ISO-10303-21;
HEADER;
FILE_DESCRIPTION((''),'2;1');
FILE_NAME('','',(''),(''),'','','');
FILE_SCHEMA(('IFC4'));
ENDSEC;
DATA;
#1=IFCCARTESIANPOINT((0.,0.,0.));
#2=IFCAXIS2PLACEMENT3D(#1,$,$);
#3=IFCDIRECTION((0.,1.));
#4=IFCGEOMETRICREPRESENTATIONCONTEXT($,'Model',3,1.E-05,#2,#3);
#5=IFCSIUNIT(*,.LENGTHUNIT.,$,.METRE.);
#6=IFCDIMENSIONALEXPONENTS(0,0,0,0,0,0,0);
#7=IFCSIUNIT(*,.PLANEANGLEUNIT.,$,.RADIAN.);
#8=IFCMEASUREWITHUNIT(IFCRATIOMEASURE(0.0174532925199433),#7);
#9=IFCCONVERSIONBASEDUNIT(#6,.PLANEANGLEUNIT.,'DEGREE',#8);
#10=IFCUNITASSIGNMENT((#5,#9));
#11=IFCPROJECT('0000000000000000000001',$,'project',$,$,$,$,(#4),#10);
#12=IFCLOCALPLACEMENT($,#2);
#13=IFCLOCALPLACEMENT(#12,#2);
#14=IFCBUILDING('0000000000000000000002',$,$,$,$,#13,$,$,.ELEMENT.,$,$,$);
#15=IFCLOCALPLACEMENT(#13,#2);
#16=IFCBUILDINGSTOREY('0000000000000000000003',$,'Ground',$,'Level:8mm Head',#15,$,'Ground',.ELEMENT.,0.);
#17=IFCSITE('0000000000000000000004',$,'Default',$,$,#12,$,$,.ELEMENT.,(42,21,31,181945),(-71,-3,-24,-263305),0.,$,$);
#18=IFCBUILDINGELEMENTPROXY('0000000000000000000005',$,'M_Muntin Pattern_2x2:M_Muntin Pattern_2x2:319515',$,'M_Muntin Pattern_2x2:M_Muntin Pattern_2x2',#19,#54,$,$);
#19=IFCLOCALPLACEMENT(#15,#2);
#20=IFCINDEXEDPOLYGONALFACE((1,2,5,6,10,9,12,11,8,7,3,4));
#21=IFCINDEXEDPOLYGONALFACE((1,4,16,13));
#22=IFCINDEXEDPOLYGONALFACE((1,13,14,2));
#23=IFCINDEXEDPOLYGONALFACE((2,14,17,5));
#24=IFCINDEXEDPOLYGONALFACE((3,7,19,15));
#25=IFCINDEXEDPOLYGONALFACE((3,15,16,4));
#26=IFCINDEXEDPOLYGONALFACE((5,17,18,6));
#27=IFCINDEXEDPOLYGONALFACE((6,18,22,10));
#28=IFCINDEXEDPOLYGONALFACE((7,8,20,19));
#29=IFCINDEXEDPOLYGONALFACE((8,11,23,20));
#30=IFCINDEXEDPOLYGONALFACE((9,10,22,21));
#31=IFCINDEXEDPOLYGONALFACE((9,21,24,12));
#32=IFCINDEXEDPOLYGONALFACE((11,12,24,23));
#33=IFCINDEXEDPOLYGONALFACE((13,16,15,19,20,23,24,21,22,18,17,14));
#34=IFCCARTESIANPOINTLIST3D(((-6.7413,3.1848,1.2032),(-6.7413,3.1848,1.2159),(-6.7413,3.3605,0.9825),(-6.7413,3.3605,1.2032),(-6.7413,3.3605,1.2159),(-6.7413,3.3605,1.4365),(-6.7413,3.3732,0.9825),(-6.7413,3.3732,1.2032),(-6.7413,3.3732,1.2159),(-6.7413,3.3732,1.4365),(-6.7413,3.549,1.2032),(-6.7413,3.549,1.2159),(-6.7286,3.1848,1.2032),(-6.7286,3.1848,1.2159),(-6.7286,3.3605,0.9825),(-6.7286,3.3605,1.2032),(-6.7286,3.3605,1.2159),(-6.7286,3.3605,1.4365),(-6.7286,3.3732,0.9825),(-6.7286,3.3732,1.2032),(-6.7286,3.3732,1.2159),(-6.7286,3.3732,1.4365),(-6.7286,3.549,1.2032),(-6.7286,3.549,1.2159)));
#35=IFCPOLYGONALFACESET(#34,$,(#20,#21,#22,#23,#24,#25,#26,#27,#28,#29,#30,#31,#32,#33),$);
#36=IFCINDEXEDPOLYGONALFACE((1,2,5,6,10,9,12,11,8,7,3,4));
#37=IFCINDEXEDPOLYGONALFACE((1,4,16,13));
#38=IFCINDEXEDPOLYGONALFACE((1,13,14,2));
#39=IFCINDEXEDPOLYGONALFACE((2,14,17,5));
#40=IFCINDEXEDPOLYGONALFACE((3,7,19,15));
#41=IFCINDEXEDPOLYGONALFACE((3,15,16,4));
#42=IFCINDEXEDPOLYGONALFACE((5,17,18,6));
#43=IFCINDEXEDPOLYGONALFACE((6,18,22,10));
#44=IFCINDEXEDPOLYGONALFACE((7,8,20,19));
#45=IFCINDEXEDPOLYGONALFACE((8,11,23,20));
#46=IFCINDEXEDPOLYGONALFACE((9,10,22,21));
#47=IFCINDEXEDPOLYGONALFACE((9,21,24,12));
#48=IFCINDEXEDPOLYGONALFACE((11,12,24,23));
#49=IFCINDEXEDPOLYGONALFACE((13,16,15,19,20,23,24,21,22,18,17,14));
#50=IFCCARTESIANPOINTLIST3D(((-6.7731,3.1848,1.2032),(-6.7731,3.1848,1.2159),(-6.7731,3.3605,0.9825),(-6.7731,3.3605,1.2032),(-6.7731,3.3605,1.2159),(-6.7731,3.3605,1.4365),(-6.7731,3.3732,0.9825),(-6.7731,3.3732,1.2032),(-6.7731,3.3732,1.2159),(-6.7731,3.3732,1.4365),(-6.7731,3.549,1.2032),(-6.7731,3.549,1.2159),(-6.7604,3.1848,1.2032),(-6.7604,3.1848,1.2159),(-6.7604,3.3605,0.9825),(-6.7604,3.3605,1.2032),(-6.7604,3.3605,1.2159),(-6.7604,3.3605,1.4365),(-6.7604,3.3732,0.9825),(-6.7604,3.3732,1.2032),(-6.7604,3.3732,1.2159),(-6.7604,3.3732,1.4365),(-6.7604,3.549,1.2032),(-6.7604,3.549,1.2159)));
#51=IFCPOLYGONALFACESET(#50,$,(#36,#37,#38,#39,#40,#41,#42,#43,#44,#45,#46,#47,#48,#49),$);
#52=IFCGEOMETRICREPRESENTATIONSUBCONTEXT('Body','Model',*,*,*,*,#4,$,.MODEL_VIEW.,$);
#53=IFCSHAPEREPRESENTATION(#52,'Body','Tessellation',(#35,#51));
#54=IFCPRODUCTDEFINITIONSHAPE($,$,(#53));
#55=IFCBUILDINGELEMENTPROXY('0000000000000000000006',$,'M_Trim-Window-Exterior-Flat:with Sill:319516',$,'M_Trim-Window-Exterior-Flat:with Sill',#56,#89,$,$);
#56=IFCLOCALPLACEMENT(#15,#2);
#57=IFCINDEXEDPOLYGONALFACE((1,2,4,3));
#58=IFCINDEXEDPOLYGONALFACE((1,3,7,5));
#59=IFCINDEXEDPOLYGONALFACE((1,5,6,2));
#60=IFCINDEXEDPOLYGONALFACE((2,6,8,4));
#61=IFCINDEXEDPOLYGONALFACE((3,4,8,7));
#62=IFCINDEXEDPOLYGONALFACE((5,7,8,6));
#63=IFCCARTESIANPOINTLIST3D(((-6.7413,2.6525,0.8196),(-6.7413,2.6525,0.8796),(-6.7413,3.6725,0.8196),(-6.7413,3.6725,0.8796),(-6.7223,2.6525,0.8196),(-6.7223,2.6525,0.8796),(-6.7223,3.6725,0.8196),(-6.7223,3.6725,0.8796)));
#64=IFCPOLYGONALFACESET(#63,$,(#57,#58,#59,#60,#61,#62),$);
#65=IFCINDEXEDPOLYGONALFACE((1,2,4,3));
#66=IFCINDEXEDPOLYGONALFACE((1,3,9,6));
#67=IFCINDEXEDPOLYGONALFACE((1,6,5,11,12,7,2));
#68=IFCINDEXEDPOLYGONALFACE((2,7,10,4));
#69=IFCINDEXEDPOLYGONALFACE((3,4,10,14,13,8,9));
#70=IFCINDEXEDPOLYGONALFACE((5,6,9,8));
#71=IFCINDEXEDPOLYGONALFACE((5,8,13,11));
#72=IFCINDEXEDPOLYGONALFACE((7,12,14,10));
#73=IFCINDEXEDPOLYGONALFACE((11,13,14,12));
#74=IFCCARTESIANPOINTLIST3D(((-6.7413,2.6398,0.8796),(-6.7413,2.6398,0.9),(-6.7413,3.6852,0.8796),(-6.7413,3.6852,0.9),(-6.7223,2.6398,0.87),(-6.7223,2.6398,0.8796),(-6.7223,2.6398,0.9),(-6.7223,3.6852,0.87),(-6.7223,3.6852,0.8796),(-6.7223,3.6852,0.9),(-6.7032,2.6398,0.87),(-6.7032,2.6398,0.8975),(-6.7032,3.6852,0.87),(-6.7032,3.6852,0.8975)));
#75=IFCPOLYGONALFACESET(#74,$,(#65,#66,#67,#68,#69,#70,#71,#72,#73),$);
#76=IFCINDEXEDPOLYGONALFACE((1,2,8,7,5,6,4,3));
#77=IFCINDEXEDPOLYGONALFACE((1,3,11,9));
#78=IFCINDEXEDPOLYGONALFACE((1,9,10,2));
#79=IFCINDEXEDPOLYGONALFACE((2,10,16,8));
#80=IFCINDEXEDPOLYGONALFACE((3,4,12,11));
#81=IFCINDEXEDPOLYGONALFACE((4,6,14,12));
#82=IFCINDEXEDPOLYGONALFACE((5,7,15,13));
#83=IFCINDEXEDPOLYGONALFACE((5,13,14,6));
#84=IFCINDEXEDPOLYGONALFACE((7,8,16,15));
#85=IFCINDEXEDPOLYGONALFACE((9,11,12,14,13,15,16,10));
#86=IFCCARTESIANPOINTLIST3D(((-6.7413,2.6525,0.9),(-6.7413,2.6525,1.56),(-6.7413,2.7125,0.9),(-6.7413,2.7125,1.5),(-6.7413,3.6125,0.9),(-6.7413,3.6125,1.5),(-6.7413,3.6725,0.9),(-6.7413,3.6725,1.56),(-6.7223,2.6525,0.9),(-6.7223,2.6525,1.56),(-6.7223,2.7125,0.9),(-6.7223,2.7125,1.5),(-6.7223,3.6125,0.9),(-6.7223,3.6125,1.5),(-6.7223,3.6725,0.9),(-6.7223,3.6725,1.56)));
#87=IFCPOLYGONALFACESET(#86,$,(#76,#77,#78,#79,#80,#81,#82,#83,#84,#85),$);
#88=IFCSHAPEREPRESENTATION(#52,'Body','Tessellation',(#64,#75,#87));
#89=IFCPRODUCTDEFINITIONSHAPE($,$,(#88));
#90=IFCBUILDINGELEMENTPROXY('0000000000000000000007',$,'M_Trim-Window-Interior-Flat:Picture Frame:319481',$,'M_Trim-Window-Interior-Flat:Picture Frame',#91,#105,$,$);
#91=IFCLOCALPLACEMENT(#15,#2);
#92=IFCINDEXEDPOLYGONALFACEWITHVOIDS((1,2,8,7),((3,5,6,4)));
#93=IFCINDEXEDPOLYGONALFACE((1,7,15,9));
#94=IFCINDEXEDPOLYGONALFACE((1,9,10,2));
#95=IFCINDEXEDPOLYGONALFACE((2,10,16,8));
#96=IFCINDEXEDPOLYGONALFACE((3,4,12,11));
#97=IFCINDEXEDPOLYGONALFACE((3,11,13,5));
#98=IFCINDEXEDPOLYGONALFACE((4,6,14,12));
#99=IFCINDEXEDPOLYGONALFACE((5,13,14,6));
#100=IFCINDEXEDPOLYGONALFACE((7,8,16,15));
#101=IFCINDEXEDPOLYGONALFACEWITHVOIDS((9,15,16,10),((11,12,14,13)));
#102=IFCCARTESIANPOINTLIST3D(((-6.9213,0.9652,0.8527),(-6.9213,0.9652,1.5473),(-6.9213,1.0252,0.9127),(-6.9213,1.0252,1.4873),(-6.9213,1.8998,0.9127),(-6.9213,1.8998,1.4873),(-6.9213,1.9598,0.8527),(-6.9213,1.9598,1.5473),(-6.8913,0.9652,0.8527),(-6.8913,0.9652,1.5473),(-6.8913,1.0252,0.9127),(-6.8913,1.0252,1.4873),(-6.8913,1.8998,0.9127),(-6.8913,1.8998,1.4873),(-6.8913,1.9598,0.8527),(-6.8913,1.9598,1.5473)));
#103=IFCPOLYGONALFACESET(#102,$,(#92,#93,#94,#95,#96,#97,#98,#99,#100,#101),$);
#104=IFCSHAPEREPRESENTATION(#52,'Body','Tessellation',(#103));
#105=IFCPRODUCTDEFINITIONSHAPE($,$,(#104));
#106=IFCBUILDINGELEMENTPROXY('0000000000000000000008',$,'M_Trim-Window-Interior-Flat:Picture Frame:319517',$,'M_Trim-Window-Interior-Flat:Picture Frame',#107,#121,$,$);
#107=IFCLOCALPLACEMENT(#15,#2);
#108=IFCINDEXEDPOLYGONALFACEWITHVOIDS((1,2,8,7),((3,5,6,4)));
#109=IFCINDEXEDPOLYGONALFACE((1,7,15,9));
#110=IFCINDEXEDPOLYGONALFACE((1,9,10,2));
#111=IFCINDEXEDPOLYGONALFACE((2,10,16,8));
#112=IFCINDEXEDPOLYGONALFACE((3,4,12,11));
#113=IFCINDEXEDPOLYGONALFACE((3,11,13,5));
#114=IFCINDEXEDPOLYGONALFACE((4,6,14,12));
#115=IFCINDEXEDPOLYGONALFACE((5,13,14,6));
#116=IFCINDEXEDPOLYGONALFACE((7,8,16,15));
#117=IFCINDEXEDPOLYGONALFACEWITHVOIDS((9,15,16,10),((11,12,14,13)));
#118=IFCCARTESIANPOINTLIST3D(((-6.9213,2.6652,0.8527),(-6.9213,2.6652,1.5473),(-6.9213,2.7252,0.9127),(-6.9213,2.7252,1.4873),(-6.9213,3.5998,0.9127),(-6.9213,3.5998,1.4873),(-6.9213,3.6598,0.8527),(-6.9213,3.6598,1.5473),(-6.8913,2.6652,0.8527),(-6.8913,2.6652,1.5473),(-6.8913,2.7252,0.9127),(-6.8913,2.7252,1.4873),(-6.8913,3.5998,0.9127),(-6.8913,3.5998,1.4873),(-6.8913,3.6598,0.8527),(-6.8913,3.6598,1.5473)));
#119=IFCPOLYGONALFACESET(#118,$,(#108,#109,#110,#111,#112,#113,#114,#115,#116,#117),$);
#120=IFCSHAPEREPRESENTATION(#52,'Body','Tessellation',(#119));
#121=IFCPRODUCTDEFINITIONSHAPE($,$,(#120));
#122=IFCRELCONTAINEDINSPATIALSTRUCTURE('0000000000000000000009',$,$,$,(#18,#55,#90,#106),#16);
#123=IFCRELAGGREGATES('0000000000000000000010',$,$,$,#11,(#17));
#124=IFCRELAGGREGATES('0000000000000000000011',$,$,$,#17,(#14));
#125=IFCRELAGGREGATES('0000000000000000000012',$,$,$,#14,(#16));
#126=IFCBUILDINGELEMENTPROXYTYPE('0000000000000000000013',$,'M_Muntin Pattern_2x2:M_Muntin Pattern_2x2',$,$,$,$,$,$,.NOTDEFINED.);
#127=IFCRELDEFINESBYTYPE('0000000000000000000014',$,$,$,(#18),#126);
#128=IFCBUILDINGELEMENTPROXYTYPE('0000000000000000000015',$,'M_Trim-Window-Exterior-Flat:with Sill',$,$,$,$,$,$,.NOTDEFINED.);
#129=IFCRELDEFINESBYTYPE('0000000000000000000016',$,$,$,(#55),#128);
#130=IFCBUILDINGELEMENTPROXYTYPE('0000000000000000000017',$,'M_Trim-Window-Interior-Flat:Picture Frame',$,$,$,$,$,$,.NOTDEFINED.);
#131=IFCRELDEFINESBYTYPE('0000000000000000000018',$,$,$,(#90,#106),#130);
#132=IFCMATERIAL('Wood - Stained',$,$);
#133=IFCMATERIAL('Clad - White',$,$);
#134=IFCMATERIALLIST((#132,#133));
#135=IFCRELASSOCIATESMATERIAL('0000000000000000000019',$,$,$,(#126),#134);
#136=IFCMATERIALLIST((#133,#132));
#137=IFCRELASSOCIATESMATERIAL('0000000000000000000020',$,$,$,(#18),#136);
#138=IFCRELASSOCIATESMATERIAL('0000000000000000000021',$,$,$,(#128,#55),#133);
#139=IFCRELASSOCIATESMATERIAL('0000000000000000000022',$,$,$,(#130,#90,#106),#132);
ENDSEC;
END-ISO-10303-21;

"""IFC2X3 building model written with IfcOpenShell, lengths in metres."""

from ifc_helpers import new_model, entity, si_unit, converted_unit, direction, frame, frame_2d, origin, place, context, subcontext, project, spatial, polyline, rectangle, outline, extrude, source, transform, mapped, material, material_list, type_object, type_shapes, element, save


model = new_model("IFC2X3")

# Units and contexts
model_context = context("Model", 3, precision=1e-05, world=origin(), true_north=direction((0.0, 1.0)))
body_context = subcontext(model_context, "Body", "Model", "MODEL_VIEW")
ifc_project = project(units=[si_unit("LENGTHUNIT", "METRE"), converted_unit("PLANEANGLEUNIT", "DEGREE", entity("IfcRatioMeasure", 0.0174532925199433), si_unit("PLANEANGLEUNIT", "RADIAN"), dimensions=[0, 0, 0, 0, 0, 0, 0])], contexts=[model_context])

# Site, building, storey
site_placement = place(None, origin())
site = spatial("IfcSite", under=ifc_project, at=site_placement, Name="Default", CompositionType="ELEMENT", RefLatitude=(42, 21, 31, 181945), RefLongitude=(-71, -3, -24, -263305), RefElevation=0.0)
building_placement = place(site_placement, origin())
building = spatial("IfcBuilding", under=site, at=building_placement, CompositionType="ELEMENT")
storey_placement = place(building_placement, origin())
storey = spatial("IfcBuildingStorey", under=building, at=storey_placement, Name="Ground", ObjectType="Level:8mm Head", LongName="Ground", CompositionType="ELEMENT", Elevation=0.0)

# Building element proxies
ifc_material_1 = material(Name="Clad - White")
ifc_material_2 = material(Name="Wood - Stained")
ifc_material_list_1 = material_list([ifc_material_2, ifc_material_1])
building_element_proxy_type_1 = type_object("IfcBuildingElementProxyType", Name="M_Muntin Pattern_2x2:M_Muntin Pattern_2x2", PredefinedType="NOTDEFINED", material=ifc_material_list_1)
shared_shape_1 = source(origin(), body_context, "Body", "SweptSolid", [
    extrude(outline(polyline([(0.0064, -0.0064), (0.227, -0.0064), (0.227, 0.0063), (0.0064, 0.0063), (0.0064, 0.1821), (-0.0063, 0.1821), (-0.0063, 0.0063), (-0.227, 0.0063), (-0.227, -0.0064), (-0.0063, -0.0064), (-0.0063, -0.1821), (0.0064, -0.1821), (0.0064, -0.0064)])), frame((0.0, 0.0095, 0.227), z_axis=(0.0, 1.0, 0.0), x_axis=(0.0, 0.0, 1.0)), (0.0, 0.0, 1.0), 0.0127),
    extrude(outline(polyline([(0.0064, -0.0064), (0.227, -0.0064), (0.227, 0.0063), (0.0064, 0.0063), (0.0064, 0.1821), (-0.0063, 0.1821), (-0.0063, 0.0063), (-0.227, 0.0063), (-0.227, -0.0064), (-0.0063, -0.0064), (-0.0063, -0.1821), (0.0064, -0.1821), (0.0064, -0.0064)])), frame((0.0, -0.0222, 0.227), z_axis=(0.0, 1.0, 0.0), x_axis=(0.0, 0.0, 1.0)), (0.0, 0.0, 1.0), 0.0127),
])
type_shapes(building_element_proxy_type_1, [shared_shape_1])
ifc_material_list_2 = material_list([ifc_material_1, ifc_material_2])
proxy_1_placement = place(storey_placement, frame((-6.7509, 3.3669, 0.9825), z_axis=(0.0, 0.0, 1.0), x_axis=(0.0, -1.0, 0.0)))
element("IfcBuildingElementProxy", 1, at=proxy_1_placement, inside=storey, type_object=building_element_proxy_type_1, material=ifc_material_list_2, Name="M_Muntin Pattern_2x2:M_Muntin Pattern_2x2:319515", ObjectType="M_Muntin Pattern_2x2:M_Muntin Pattern_2x2", context=body_context, shape_type="MappedRepresentation", body=[
    mapped(shared_shape_1, transform((0.0, 0.0, 0.0), scale=1.0)),
])
building_element_proxy_type_2 = type_object("IfcBuildingElementProxyType", Name="M_Trim-Window-Exterior-Flat:with Sill", PredefinedType="NOTDEFINED", material=ifc_material_1)
shared_shape_2 = source(origin(), body_context, "Body", "SweptSolid", [
    extrude(rectangle(XDim=1.02, YDim=0.06, at=frame_2d((0.0, 0.0), x_axis=(1.0, 0.0))), frame((0.0, -0.6504, 0.0), z_axis=(0.0, 0.0, 1.0), x_axis=(-1.0, 0.0, 0.0)), (0.0, 0.0, 1.0), 0.0191),
    extrude(outline(polyline([(-0.019, -0.0152), (0.0, -0.0152), (0.0, -0.0057), (0.019, -0.0057), (0.019, 0.0148), (0.0, 0.0148), (-0.019, 0.0123), (-0.019, -0.0152)])), frame((-0.5227, -0.6148, 0.019), z_axis=(1.0, 0.0, 0.0), x_axis=(0.0, 0.0, -1.0)), (0.0, 0.0, 1.0), 1.0454),
    extrude(outline(polyline([(-0.345, -0.51), (0.315, -0.51), (0.315, -0.45), (-0.285, -0.45), (-0.285, 0.45), (0.315, 0.45), (0.315, 0.51), (-0.345, 0.51), (-0.345, -0.51)])), frame((0.0, -0.285, 0.0), z_axis=(0.0, 0.0, 1.0), x_axis=(0.0, -1.0, 0.0)), (0.0, 0.0, 1.0), 0.0191),
])
type_shapes(building_element_proxy_type_2, [shared_shape_2])
proxy_2_placement = place(storey_placement, frame((-6.7413, 3.1625, 1.5), z_axis=(1.0, 0.0, 0.0), x_axis=(0.0, 1.0, 0.0)))
element("IfcBuildingElementProxy", 2, at=proxy_2_placement, inside=storey, type_object=building_element_proxy_type_2, material=ifc_material_1, Name="M_Trim-Window-Exterior-Flat:with Sill:319516", ObjectType="M_Trim-Window-Exterior-Flat:with Sill", context=body_context, shape_type="MappedRepresentation", body=[
    mapped(shared_shape_2, transform((0.0, 0.0, 0.0), scale=1.0)),
])
building_element_proxy_type_3 = type_object("IfcBuildingElementProxyType", Name="M_Trim-Window-Interior-Flat:Picture Frame", PredefinedType="NOTDEFINED", material=ifc_material_2)
shared_shape_3 = source(origin(), body_context, "Body", "SweptSolid", [
    extrude(outline(polyline([(-0.4973, -0.3473), (0.4973, -0.3473), (0.4973, 0.3473), (-0.4973, 0.3473), (-0.4973, -0.3473)]), holes=[polyline([(-0.4373, -0.2873), (-0.4373, 0.2873), (0.4373, 0.2873), (0.4373, -0.2873), (-0.4373, -0.2873)])]), frame((0.0, -0.3, 0.0), z_axis=(0.0, 0.0, 1.0), x_axis=(-1.0, 0.0, 0.0)), (0.0, 0.0, 1.0), 0.03),
])
type_shapes(building_element_proxy_type_3, [shared_shape_3])
for number, where, z_axis, x_axis, name in (
    (3, (-6.8913, 1.4625, 1.5), (-1.0, 0.0, 0.0), (0.0, -1.0, 0.0), "M_Trim-Window-Interior-Flat:Picture Frame:319481"),
    (4, (-6.8913, 3.1625, 1.5), (-1.0, 0.0, 0.0), (0.0, -1.0, 0.0), "M_Trim-Window-Interior-Flat:Picture Frame:319517"),
):
    element("IfcBuildingElementProxy", number, at=place(storey_placement, frame(where, z_axis=z_axis, x_axis=x_axis)), inside=storey, type_object=building_element_proxy_type_3, material=ifc_material_2, Name=name, ObjectType="M_Trim-Window-Interior-Flat:Picture Frame", context=body_context, shape_type="MappedRepresentation", body=[
        mapped(shared_shape_3, transform((0.0, 0.0, 0.0), scale=1.0)),
    ])

save(model, "model.ifc")
